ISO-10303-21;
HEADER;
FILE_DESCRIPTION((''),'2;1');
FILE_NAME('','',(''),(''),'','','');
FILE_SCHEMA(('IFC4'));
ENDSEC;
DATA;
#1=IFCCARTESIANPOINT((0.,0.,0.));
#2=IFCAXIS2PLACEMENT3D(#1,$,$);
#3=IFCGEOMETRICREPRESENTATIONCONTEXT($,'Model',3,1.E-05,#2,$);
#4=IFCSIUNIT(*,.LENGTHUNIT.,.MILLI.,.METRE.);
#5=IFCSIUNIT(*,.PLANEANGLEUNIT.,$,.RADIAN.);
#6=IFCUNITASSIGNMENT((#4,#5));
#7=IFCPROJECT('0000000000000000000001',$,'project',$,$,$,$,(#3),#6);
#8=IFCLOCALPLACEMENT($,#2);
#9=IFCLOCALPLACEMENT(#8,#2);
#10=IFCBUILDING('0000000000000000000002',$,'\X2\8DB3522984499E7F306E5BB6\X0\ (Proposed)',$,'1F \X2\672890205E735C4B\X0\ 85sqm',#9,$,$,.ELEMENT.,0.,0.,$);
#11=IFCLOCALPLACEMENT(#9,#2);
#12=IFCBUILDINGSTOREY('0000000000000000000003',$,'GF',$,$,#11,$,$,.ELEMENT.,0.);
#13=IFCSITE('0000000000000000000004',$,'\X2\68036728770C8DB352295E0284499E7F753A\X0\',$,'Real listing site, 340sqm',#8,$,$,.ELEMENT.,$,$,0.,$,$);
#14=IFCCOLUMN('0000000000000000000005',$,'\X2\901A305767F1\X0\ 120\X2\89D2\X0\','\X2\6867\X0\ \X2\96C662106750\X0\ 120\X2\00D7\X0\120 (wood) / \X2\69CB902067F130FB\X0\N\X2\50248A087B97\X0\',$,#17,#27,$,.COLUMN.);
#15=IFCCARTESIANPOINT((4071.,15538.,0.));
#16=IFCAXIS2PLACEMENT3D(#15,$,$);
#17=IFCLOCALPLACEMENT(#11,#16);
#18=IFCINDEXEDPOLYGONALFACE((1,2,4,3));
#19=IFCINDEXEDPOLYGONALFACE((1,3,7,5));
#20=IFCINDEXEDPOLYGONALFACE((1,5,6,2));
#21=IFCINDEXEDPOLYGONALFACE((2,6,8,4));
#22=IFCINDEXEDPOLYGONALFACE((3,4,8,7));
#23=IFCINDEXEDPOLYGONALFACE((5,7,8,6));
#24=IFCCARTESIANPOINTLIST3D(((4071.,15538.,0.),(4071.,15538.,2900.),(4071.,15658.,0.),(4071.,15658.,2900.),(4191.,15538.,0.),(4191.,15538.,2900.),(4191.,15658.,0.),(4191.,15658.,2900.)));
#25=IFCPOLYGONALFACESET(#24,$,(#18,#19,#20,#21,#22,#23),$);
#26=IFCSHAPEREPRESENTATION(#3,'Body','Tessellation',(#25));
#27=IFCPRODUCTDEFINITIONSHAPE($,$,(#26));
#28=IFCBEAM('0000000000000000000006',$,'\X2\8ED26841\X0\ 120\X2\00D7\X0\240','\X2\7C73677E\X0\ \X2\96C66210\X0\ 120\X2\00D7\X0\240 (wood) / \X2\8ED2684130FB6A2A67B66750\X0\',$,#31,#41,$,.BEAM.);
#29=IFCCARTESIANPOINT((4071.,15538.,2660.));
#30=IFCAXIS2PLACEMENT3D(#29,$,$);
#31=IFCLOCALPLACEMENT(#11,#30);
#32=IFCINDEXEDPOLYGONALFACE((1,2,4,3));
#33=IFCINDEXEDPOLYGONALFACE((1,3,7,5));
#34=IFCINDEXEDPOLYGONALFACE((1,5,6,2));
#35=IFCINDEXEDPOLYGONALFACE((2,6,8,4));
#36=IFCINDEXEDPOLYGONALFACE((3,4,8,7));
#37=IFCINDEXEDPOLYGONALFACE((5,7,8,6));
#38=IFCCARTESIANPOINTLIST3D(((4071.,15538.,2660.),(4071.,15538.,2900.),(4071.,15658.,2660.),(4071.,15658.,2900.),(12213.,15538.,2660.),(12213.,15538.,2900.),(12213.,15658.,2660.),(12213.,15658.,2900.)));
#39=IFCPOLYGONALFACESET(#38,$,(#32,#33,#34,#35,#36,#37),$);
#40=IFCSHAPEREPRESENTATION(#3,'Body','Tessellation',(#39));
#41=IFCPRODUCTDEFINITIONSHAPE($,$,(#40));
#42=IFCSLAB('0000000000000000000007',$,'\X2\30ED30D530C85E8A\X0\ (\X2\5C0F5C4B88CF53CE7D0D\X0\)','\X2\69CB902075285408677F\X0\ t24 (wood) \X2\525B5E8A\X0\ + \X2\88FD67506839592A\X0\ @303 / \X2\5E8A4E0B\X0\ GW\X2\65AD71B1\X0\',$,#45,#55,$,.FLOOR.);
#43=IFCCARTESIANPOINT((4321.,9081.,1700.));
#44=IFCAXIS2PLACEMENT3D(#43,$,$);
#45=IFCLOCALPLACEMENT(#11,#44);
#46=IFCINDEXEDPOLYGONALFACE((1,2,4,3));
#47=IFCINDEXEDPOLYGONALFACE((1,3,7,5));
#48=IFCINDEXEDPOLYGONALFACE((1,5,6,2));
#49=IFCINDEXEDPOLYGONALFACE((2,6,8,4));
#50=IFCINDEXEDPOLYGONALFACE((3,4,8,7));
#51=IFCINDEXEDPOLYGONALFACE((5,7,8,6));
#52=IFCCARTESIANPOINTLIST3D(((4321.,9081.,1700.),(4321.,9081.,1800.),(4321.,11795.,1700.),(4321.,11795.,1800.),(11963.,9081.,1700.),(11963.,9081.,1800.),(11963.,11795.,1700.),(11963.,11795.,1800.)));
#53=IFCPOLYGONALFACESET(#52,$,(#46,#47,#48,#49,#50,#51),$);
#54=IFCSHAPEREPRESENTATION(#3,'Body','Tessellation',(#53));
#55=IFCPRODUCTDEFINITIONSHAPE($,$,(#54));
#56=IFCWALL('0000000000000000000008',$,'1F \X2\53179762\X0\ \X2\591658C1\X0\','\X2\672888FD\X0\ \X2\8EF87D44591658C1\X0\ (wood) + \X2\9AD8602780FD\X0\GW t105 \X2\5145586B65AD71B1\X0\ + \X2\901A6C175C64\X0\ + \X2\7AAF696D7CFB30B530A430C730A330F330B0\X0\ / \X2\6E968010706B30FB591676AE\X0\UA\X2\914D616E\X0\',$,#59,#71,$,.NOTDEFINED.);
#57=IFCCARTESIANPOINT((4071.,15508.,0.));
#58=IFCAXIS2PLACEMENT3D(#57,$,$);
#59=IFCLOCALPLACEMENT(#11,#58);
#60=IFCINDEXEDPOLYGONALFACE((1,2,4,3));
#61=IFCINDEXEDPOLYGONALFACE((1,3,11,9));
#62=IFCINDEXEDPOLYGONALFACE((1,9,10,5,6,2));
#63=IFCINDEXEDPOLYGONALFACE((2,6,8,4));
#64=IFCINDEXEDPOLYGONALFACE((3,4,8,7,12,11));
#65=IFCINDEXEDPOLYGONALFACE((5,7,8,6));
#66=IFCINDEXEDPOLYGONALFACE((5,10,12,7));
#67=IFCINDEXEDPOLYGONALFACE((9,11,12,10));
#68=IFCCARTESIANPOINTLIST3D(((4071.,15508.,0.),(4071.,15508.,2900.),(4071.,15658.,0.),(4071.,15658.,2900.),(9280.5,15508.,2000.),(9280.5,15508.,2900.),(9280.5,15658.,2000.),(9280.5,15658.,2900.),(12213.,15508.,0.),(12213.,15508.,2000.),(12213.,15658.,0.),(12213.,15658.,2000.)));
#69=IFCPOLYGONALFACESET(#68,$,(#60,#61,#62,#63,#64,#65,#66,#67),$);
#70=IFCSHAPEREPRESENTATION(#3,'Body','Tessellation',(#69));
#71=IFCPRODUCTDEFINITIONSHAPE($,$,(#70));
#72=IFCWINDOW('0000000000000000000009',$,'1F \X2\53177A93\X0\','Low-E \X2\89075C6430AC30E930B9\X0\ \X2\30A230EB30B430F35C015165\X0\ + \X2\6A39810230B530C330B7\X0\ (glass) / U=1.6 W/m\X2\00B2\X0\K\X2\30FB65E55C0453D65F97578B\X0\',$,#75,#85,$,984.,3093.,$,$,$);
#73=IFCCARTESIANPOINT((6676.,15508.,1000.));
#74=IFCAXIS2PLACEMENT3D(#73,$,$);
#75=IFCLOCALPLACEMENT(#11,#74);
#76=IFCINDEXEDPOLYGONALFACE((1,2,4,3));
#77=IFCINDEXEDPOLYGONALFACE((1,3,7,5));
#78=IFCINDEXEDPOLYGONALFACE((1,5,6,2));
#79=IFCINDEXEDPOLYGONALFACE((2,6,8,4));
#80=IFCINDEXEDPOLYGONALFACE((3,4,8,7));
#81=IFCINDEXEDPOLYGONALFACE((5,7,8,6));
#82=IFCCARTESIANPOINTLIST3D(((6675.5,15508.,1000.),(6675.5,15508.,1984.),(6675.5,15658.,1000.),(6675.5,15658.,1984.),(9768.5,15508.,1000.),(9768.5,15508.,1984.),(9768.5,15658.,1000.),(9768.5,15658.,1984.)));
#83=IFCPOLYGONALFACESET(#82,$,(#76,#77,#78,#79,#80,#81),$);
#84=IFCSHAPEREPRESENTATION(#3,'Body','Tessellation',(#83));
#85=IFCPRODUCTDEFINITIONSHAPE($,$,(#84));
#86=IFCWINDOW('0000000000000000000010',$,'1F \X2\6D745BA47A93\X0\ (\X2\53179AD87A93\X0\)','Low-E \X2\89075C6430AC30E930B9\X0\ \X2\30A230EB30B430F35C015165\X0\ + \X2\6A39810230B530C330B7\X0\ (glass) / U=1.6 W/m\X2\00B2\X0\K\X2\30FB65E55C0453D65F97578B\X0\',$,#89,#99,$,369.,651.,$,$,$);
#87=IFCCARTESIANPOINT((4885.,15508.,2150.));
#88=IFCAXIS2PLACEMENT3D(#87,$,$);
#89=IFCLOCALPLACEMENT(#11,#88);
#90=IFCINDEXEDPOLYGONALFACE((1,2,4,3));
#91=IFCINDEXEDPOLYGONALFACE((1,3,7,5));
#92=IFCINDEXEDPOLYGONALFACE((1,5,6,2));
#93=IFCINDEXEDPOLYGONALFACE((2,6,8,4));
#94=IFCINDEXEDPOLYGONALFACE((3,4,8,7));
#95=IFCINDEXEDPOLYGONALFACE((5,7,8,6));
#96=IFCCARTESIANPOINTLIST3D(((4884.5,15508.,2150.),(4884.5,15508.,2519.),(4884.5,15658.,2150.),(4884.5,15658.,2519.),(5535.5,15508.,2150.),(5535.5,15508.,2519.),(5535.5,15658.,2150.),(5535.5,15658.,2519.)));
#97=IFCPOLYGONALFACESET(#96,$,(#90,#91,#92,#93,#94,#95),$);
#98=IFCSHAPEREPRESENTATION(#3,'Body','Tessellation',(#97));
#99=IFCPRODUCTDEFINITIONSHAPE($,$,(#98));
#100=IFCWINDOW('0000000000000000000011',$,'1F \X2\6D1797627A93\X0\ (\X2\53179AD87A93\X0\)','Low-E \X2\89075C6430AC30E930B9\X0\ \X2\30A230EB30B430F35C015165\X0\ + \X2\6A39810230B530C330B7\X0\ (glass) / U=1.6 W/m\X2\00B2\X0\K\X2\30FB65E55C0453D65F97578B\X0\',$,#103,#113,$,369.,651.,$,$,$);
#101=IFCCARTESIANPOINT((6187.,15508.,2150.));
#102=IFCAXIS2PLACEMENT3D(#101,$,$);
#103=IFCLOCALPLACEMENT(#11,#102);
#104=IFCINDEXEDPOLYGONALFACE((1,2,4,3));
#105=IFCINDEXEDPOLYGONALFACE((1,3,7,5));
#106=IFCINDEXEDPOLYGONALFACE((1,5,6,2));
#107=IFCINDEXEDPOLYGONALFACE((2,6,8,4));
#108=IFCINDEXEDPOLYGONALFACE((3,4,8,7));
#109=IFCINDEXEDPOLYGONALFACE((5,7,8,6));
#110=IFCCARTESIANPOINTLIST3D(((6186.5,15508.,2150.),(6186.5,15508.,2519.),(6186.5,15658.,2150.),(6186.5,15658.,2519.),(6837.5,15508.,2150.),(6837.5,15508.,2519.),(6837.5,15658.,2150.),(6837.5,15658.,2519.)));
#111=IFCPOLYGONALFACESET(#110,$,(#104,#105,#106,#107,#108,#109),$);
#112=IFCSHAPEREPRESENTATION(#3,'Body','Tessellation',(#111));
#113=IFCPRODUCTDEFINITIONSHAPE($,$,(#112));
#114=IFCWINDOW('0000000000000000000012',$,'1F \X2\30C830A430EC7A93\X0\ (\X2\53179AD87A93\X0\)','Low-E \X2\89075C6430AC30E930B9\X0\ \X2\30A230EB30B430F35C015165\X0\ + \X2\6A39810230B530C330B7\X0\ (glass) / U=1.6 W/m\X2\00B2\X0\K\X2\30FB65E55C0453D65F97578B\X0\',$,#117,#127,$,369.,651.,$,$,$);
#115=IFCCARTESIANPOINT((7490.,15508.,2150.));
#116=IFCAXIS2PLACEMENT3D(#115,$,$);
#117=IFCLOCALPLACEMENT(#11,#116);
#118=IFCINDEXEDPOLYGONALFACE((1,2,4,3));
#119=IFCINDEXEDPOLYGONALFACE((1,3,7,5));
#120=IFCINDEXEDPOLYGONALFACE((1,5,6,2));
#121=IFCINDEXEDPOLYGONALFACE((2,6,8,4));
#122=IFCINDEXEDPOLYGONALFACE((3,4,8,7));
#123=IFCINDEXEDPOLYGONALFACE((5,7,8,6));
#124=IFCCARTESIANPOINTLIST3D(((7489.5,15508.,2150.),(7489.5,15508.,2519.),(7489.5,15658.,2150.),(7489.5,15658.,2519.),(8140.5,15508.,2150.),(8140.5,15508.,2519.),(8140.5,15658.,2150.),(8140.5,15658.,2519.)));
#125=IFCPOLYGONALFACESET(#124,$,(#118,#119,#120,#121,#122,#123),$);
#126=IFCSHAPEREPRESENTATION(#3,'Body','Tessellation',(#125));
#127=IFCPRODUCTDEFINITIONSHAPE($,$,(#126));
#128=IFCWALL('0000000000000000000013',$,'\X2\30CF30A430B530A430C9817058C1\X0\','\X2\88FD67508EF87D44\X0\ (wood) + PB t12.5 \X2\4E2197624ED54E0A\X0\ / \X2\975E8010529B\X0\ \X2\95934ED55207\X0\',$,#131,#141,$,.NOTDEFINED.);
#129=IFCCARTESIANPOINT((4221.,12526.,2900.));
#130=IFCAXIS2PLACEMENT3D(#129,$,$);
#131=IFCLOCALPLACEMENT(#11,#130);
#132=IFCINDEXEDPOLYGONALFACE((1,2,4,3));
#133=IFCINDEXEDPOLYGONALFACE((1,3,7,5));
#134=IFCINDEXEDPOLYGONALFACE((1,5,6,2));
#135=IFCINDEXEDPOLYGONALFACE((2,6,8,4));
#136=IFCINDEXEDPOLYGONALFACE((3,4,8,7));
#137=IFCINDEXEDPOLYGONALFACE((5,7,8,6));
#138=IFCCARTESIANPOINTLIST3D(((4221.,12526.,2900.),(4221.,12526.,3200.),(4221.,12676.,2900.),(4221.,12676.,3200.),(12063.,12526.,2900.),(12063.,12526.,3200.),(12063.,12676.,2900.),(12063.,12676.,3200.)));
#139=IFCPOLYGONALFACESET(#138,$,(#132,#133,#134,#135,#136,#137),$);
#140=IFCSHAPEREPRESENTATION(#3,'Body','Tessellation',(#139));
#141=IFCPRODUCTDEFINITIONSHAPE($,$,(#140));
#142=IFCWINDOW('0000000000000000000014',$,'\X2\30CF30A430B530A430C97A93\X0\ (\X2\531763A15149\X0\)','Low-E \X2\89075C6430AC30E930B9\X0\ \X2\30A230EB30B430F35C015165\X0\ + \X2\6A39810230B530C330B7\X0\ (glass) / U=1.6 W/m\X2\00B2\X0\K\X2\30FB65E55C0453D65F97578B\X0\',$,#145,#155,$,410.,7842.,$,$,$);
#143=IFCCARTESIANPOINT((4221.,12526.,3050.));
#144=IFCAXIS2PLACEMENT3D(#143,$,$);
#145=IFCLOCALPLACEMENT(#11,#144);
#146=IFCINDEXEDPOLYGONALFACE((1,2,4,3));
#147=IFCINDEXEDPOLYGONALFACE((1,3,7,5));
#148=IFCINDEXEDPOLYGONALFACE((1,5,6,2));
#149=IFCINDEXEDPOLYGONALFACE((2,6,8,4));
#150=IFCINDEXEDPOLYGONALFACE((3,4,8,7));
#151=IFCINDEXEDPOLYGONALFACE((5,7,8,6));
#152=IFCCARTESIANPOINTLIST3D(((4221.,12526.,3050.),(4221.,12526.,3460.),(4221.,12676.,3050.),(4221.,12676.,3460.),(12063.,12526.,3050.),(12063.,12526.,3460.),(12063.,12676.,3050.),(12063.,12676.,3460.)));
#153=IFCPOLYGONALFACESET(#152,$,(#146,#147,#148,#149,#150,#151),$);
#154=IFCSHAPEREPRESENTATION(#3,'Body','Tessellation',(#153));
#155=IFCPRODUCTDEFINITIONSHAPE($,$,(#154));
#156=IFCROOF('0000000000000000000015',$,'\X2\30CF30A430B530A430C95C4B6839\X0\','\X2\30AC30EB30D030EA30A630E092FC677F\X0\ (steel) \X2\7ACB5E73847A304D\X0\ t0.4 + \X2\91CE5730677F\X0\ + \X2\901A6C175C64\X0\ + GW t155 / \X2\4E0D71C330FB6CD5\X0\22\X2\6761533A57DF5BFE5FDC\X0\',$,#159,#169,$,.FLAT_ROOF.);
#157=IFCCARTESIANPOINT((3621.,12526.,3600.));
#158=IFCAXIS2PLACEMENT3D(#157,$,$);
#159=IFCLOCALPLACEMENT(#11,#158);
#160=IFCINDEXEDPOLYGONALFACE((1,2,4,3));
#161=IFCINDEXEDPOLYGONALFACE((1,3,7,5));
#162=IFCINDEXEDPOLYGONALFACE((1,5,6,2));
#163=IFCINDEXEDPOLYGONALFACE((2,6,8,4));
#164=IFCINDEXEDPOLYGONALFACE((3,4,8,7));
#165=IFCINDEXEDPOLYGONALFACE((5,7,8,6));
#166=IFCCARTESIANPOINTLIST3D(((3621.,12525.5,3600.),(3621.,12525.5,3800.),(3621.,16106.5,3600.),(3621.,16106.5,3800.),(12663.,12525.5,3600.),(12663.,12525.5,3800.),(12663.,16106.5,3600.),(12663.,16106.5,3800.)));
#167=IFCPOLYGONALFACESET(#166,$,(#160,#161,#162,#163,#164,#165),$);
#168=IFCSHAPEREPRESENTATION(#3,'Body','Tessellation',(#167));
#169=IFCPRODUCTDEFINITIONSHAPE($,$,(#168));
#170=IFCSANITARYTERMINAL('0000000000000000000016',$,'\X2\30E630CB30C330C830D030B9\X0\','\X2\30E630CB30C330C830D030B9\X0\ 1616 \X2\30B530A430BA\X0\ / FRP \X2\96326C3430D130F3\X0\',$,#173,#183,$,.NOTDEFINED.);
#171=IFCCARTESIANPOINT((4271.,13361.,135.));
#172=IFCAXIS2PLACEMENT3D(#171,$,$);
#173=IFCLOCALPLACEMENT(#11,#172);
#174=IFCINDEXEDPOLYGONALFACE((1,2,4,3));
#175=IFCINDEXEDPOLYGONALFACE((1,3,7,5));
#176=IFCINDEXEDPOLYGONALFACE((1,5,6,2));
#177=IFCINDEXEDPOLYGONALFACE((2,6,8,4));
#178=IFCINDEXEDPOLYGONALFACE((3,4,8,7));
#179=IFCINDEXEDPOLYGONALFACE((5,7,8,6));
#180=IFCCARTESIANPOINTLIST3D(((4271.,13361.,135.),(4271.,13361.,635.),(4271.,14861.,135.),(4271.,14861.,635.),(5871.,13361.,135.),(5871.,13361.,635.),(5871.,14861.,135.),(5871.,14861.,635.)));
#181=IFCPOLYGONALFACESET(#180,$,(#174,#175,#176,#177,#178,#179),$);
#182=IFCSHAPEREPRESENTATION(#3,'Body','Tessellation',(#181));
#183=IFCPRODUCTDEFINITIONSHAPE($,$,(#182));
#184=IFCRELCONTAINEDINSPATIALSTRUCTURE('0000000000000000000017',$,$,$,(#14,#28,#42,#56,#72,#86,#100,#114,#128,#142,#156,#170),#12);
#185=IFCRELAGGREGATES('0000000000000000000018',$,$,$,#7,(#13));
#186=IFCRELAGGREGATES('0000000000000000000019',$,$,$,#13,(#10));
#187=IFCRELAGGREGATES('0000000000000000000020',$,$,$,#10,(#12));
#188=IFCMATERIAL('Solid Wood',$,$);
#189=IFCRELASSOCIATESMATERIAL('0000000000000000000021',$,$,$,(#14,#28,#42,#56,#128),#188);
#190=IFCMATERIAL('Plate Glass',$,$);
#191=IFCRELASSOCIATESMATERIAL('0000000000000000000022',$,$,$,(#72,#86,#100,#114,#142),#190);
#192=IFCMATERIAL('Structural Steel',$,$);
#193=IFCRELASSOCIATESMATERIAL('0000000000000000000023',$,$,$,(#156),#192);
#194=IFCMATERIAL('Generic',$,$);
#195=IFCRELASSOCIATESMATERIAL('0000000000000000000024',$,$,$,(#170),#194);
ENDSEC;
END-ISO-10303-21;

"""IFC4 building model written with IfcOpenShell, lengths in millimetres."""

from ifc_helpers import new_model, si_unit, frame, frame_2d, origin, place, context, project, spatial, rectangle, extrude, material, element, fill, save


model = new_model("IFC4")

# Units and contexts
model_context = context("Model", 3, precision=1e-05, world=origin())
ifc_project = project(units=[si_unit("LENGTHUNIT", "METRE", prefix="MILLI"), si_unit("PLANEANGLEUNIT", "RADIAN")], contexts=[model_context])

# Site, building, storey
site_placement = place(None, origin())
site = spatial("IfcSite", under=ifc_project, at=site_placement, Name="栃木県足利市葉鹿町", ObjectType="Real listing site, 340sqm", CompositionType="ELEMENT", RefElevation=0.0)
building_placement = place(site_placement, origin())
building = spatial("IfcBuilding", under=site, at=building_placement, Name="足利葉鹿の家 (Proposed)", ObjectType="1F 木造平屋 85sqm", CompositionType="ELEMENT", ElevationOfRefHeight=0.0, ElevationOfTerrain=0.0)
storey_placement = place(building_placement, origin())
storey = spatial("IfcBuildingStorey", under=building, at=storey_placement, Name="GF", CompositionType="ELEMENT", Elevation=0.0)

# Column
ifc_material_1 = material(Name="Solid Wood")
column_1_placement = place(storey_placement, frame((4071.0, 15538.0, 0.0)))
element("IfcColumn", 1, at=column_1_placement, inside=storey, material=ifc_material_1, Name="通し柱 120角", Description="桧 集成材 120×120 (wood) / 構造柱・N値計算", PredefinedType="COLUMN", context=model_context, shape_type="SweptSolid", body=[
    extrude(rectangle(XDim=120.0, YDim=120.0, at=frame_2d((60.0, 60.0))), frame((4071.0, 15538.0, 0.0)), (0.0, 0.0, 1.0), 2900.0),
])

# Beam
beam_1_placement = place(storey_placement, frame((4071.0, 15538.0, 2660.0)))
element("IfcBeam", 2, at=beam_1_placement, inside=storey, material=ifc_material_1, Name="軒桁 120×240", Description="米松 集成 120×240 (wood) / 軒桁・横架材", PredefinedType="BEAM", context=model_context, shape_type="SweptSolid", body=[
    extrude(rectangle(XDim=8142.0, YDim=120.0, at=frame_2d((4071.0, 60.0))), frame((4071.0, 15538.0, 2660.0)), (0.0, 0.0, 1.0), 240.0),
])

# Slab
slab_placement = place(storey_placement, frame((4321.0, 9081.0, 1700.0)))
element("IfcSlab", 3, at=slab_placement, inside=storey, material=ifc_material_1, Name="ロフト床 (小屋裏収納)", Description="構造用合板 t24 (wood) 剛床 + 製材根太 @303 / 床下 GW断熱", PredefinedType="FLOOR", context=model_context, shape_type="SweptSolid", body=[
    extrude(rectangle(XDim=7642.0, YDim=2714.0, at=frame_2d((3821.0, 1357.0))), frame((4321.0, 9081.0, 1700.0)), (0.0, 0.0, 1.0), 100.0),
])

# Wall, openings, windows
wall_1_placement = place(storey_placement, frame((4071.0, 15508.0, 0.0)))
wall_1 = element("IfcWall", 4, at=wall_1_placement, inside=storey, material=ifc_material_1, Name="1F 北面 外壁", Description="木製 軸組外壁 (wood) + 高性能GW t105 充填断熱 + 通気層 + 窯業系サイディング / 準耐火・外皮UA配慮", PredefinedType="NOTDEFINED", context=model_context, shape_type="SweptSolid", body=[
    extrude(rectangle(XDim=8142.0, YDim=150.0, at=frame_2d((4071.0, 75.0))), frame((4071.0, 15508.0, 0.0)), (0.0, 0.0, 1.0), 2900.0),
])
opening_1_placement = place(storey_placement, frame((6676.0, 15508.0, 1000.0)))
opening_1 = element("IfcOpeningElement", 5, at=opening_1_placement, cuts=wall_1, PredefinedType="NOTDEFINED", context=model_context, shape_type="SweptSolid", body=[
    extrude(rectangle(XDim=3093.0, YDim=150.0, at=frame_2d((1546.0, 75.0))), frame((6676.0, 15508.0, 1000.0)), (0.0, 0.0, 1.0), 984.0),
])
opening_2_placement = place(storey_placement, frame((4885.0, 15508.0, 2150.0)))
opening_2 = element("IfcOpeningElement", 6, at=opening_2_placement, cuts=wall_1, PredefinedType="NOTDEFINED", context=model_context, shape_type="SweptSolid", body=[
    extrude(rectangle(XDim=651.0, YDim=150.0, at=frame_2d((325.0, 75.0))), frame((4885.0, 15508.0, 2150.0)), (0.0, 0.0, 1.0), 369.0),
])
opening_3_placement = place(storey_placement, frame((6187.0, 15508.0, 2150.0)))
opening_3 = element("IfcOpeningElement", 7, at=opening_3_placement, cuts=wall_1, PredefinedType="NOTDEFINED", context=model_context, shape_type="SweptSolid", body=[
    extrude(rectangle(XDim=651.0, YDim=150.0, at=frame_2d((325.0, 75.0))), frame((6187.0, 15508.0, 2150.0)), (0.0, 0.0, 1.0), 369.0),
])
opening_4_placement = place(storey_placement, frame((7490.0, 15508.0, 2150.0)))
opening_4 = element("IfcOpeningElement", 8, at=opening_4_placement, cuts=wall_1, PredefinedType="NOTDEFINED", context=model_context, shape_type="SweptSolid", body=[
    extrude(rectangle(XDim=651.0, YDim=150.0, at=frame_2d((325.0, 75.0))), frame((7490.0, 15508.0, 2150.0)), (0.0, 0.0, 1.0), 369.0),
])
ifc_material_2 = material(Name="Plate Glass")
window_1_placement = place(storey_placement, frame((6676.0, 15508.0, 1000.0)))
window_1 = element("IfcWindow", 9, at=window_1_placement, inside=storey, material=ifc_material_2, Name="1F 北窓", Description="Low-E 複層ガラス アルゴン封入 + 樹脂サッシ (glass) / U=1.6 W/m²K・日射取得型", OverallHeight=984.0, OverallWidth=3093.0, context=model_context, shape_type="SweptSolid", body=[
    extrude(rectangle(XDim=3093.0, YDim=150.0, at=frame_2d((1546.0, 75.0))), frame((6676.0, 15508.0, 1000.0)), (0.0, 0.0, 1.0), 984.0),
])
fill(opening_1, window_1)
window_2_placement = place(storey_placement, frame((4885.0, 15508.0, 2150.0)))
window_2 = element("IfcWindow", 10, at=window_2_placement, inside=storey, material=ifc_material_2, Name="1F 浴室窓 (北高窓)", Description="Low-E 複層ガラス アルゴン封入 + 樹脂サッシ (glass) / U=1.6 W/m²K・日射取得型", OverallHeight=369.0, OverallWidth=651.0, context=model_context, shape_type="SweptSolid", body=[
    extrude(rectangle(XDim=651.0, YDim=150.0, at=frame_2d((325.0, 75.0))), frame((4885.0, 15508.0, 2150.0)), (0.0, 0.0, 1.0), 369.0),
])
fill(opening_2, window_2)
window_3_placement = place(storey_placement, frame((6187.0, 15508.0, 2150.0)))
window_3 = element("IfcWindow", 11, at=window_3_placement, inside=storey, material=ifc_material_2, Name="1F 洗面窓 (北高窓)", Description="Low-E 複層ガラス アルゴン封入 + 樹脂サッシ (glass) / U=1.6 W/m²K・日射取得型", OverallHeight=369.0, OverallWidth=651.0, context=model_context, shape_type="SweptSolid", body=[
    extrude(rectangle(XDim=651.0, YDim=150.0, at=frame_2d((325.0, 75.0))), frame((6187.0, 15508.0, 2150.0)), (0.0, 0.0, 1.0), 369.0),
])
fill(opening_3, window_3)
window_4_placement = place(storey_placement, frame((7490.0, 15508.0, 2150.0)))
window_4 = element("IfcWindow", 12, at=window_4_placement, inside=storey, material=ifc_material_2, Name="1F トイレ窓 (北高窓)", Description="Low-E 複層ガラス アルゴン封入 + 樹脂サッシ (glass) / U=1.6 W/m²K・日射取得型", OverallHeight=369.0, OverallWidth=651.0, context=model_context, shape_type="SweptSolid", body=[
    extrude(rectangle(XDim=651.0, YDim=150.0, at=frame_2d((325.0, 75.0))), frame((7490.0, 15508.0, 2150.0)), (0.0, 0.0, 1.0), 369.0),
])
fill(opening_4, window_4)

# Wall, opening, window
wall_2_placement = place(storey_placement, frame((4221.0, 12526.0, 2900.0)))
wall_2 = element("IfcWall", 13, at=wall_2_placement, inside=storey, material=ifc_material_1, Name="ハイサイド腰壁", Description="製材軸組 (wood) + PB t12.5 両面仕上 / 非耐力 間仕切", PredefinedType="NOTDEFINED", context=model_context, shape_type="SweptSolid", body=[
    extrude(rectangle(XDim=7842.0, YDim=150.0, at=frame_2d((3921.0, 75.0))), frame((4221.0, 12526.0, 2900.0)), (0.0, 0.0, 1.0), 700.0),
])
opening_5_placement = place(storey_placement, frame((4221.0, 12526.0, 3050.0)))
opening_5 = element("IfcOpeningElement", 14, at=opening_5_placement, cuts=wall_2, PredefinedType="NOTDEFINED", context=model_context, shape_type="SweptSolid", body=[
    extrude(rectangle(XDim=7842.0, YDim=150.0, at=frame_2d((3921.0, 75.0))), frame((4221.0, 12526.0, 3050.0)), (0.0, 0.0, 1.0), 410.0),
])
window_5_placement = place(storey_placement, frame((4221.0, 12526.0, 3050.0)))
window_5 = element("IfcWindow", 15, at=window_5_placement, inside=storey, material=ifc_material_2, Name="ハイサイド窓 (北採光)", Description="Low-E 複層ガラス アルゴン封入 + 樹脂サッシ (glass) / U=1.6 W/m²K・日射取得型", OverallHeight=410.0, OverallWidth=7842.0, context=model_context, shape_type="SweptSolid", body=[
    extrude(rectangle(XDim=7842.0, YDim=150.0, at=frame_2d((3921.0, 75.0))), frame((4221.0, 12526.0, 3050.0)), (0.0, 0.0, 1.0), 410.0),
])
fill(opening_5, window_5)

# Roof
ifc_material_3 = material(Name="Structural Steel")
roof_placement = place(storey_placement, frame((3621.0, 12526.0, 3600.0)))
element("IfcRoof", 16, at=roof_placement, inside=storey, material=ifc_material_3, Name="ハイサイド屋根", Description="ガルバリウム鋼板 (steel) 立平葺き t0.4 + 野地板 + 通気層 + GW t155 / 不燃・法22条区域対応", PredefinedType="FLAT_ROOF", context=model_context, shape_type="SweptSolid", body=[
    extrude(rectangle(XDim=9042.0, YDim=3581.0, at=frame_2d((4521.0, 1790.0))), frame((3621.0, 12526.0, 3600.0)), (0.0, 0.0, 1.0), 200.0),
])

# Sanitary terminal
ifc_material_4 = material(Name="Generic")
sanitary_terminal_placement = place(storey_placement, frame((4271.0, 13361.0, 135.0)))
element("IfcSanitaryTerminal", 17, at=sanitary_terminal_placement, inside=storey, material=ifc_material_4, Name="ユニットバス", Description="ユニットバス 1616 サイズ / FRP 防水パン", PredefinedType="NOTDEFINED", context=model_context, shape_type="SweptSolid", body=[
    extrude(rectangle(XDim=1600.0, YDim=1500.0, at=frame_2d((800.0, 750.0))), frame((4271.0, 13361.0, 135.0)), (0.0, 0.0, 1.0), 500.0),
])

save(model, "model.ifc")
